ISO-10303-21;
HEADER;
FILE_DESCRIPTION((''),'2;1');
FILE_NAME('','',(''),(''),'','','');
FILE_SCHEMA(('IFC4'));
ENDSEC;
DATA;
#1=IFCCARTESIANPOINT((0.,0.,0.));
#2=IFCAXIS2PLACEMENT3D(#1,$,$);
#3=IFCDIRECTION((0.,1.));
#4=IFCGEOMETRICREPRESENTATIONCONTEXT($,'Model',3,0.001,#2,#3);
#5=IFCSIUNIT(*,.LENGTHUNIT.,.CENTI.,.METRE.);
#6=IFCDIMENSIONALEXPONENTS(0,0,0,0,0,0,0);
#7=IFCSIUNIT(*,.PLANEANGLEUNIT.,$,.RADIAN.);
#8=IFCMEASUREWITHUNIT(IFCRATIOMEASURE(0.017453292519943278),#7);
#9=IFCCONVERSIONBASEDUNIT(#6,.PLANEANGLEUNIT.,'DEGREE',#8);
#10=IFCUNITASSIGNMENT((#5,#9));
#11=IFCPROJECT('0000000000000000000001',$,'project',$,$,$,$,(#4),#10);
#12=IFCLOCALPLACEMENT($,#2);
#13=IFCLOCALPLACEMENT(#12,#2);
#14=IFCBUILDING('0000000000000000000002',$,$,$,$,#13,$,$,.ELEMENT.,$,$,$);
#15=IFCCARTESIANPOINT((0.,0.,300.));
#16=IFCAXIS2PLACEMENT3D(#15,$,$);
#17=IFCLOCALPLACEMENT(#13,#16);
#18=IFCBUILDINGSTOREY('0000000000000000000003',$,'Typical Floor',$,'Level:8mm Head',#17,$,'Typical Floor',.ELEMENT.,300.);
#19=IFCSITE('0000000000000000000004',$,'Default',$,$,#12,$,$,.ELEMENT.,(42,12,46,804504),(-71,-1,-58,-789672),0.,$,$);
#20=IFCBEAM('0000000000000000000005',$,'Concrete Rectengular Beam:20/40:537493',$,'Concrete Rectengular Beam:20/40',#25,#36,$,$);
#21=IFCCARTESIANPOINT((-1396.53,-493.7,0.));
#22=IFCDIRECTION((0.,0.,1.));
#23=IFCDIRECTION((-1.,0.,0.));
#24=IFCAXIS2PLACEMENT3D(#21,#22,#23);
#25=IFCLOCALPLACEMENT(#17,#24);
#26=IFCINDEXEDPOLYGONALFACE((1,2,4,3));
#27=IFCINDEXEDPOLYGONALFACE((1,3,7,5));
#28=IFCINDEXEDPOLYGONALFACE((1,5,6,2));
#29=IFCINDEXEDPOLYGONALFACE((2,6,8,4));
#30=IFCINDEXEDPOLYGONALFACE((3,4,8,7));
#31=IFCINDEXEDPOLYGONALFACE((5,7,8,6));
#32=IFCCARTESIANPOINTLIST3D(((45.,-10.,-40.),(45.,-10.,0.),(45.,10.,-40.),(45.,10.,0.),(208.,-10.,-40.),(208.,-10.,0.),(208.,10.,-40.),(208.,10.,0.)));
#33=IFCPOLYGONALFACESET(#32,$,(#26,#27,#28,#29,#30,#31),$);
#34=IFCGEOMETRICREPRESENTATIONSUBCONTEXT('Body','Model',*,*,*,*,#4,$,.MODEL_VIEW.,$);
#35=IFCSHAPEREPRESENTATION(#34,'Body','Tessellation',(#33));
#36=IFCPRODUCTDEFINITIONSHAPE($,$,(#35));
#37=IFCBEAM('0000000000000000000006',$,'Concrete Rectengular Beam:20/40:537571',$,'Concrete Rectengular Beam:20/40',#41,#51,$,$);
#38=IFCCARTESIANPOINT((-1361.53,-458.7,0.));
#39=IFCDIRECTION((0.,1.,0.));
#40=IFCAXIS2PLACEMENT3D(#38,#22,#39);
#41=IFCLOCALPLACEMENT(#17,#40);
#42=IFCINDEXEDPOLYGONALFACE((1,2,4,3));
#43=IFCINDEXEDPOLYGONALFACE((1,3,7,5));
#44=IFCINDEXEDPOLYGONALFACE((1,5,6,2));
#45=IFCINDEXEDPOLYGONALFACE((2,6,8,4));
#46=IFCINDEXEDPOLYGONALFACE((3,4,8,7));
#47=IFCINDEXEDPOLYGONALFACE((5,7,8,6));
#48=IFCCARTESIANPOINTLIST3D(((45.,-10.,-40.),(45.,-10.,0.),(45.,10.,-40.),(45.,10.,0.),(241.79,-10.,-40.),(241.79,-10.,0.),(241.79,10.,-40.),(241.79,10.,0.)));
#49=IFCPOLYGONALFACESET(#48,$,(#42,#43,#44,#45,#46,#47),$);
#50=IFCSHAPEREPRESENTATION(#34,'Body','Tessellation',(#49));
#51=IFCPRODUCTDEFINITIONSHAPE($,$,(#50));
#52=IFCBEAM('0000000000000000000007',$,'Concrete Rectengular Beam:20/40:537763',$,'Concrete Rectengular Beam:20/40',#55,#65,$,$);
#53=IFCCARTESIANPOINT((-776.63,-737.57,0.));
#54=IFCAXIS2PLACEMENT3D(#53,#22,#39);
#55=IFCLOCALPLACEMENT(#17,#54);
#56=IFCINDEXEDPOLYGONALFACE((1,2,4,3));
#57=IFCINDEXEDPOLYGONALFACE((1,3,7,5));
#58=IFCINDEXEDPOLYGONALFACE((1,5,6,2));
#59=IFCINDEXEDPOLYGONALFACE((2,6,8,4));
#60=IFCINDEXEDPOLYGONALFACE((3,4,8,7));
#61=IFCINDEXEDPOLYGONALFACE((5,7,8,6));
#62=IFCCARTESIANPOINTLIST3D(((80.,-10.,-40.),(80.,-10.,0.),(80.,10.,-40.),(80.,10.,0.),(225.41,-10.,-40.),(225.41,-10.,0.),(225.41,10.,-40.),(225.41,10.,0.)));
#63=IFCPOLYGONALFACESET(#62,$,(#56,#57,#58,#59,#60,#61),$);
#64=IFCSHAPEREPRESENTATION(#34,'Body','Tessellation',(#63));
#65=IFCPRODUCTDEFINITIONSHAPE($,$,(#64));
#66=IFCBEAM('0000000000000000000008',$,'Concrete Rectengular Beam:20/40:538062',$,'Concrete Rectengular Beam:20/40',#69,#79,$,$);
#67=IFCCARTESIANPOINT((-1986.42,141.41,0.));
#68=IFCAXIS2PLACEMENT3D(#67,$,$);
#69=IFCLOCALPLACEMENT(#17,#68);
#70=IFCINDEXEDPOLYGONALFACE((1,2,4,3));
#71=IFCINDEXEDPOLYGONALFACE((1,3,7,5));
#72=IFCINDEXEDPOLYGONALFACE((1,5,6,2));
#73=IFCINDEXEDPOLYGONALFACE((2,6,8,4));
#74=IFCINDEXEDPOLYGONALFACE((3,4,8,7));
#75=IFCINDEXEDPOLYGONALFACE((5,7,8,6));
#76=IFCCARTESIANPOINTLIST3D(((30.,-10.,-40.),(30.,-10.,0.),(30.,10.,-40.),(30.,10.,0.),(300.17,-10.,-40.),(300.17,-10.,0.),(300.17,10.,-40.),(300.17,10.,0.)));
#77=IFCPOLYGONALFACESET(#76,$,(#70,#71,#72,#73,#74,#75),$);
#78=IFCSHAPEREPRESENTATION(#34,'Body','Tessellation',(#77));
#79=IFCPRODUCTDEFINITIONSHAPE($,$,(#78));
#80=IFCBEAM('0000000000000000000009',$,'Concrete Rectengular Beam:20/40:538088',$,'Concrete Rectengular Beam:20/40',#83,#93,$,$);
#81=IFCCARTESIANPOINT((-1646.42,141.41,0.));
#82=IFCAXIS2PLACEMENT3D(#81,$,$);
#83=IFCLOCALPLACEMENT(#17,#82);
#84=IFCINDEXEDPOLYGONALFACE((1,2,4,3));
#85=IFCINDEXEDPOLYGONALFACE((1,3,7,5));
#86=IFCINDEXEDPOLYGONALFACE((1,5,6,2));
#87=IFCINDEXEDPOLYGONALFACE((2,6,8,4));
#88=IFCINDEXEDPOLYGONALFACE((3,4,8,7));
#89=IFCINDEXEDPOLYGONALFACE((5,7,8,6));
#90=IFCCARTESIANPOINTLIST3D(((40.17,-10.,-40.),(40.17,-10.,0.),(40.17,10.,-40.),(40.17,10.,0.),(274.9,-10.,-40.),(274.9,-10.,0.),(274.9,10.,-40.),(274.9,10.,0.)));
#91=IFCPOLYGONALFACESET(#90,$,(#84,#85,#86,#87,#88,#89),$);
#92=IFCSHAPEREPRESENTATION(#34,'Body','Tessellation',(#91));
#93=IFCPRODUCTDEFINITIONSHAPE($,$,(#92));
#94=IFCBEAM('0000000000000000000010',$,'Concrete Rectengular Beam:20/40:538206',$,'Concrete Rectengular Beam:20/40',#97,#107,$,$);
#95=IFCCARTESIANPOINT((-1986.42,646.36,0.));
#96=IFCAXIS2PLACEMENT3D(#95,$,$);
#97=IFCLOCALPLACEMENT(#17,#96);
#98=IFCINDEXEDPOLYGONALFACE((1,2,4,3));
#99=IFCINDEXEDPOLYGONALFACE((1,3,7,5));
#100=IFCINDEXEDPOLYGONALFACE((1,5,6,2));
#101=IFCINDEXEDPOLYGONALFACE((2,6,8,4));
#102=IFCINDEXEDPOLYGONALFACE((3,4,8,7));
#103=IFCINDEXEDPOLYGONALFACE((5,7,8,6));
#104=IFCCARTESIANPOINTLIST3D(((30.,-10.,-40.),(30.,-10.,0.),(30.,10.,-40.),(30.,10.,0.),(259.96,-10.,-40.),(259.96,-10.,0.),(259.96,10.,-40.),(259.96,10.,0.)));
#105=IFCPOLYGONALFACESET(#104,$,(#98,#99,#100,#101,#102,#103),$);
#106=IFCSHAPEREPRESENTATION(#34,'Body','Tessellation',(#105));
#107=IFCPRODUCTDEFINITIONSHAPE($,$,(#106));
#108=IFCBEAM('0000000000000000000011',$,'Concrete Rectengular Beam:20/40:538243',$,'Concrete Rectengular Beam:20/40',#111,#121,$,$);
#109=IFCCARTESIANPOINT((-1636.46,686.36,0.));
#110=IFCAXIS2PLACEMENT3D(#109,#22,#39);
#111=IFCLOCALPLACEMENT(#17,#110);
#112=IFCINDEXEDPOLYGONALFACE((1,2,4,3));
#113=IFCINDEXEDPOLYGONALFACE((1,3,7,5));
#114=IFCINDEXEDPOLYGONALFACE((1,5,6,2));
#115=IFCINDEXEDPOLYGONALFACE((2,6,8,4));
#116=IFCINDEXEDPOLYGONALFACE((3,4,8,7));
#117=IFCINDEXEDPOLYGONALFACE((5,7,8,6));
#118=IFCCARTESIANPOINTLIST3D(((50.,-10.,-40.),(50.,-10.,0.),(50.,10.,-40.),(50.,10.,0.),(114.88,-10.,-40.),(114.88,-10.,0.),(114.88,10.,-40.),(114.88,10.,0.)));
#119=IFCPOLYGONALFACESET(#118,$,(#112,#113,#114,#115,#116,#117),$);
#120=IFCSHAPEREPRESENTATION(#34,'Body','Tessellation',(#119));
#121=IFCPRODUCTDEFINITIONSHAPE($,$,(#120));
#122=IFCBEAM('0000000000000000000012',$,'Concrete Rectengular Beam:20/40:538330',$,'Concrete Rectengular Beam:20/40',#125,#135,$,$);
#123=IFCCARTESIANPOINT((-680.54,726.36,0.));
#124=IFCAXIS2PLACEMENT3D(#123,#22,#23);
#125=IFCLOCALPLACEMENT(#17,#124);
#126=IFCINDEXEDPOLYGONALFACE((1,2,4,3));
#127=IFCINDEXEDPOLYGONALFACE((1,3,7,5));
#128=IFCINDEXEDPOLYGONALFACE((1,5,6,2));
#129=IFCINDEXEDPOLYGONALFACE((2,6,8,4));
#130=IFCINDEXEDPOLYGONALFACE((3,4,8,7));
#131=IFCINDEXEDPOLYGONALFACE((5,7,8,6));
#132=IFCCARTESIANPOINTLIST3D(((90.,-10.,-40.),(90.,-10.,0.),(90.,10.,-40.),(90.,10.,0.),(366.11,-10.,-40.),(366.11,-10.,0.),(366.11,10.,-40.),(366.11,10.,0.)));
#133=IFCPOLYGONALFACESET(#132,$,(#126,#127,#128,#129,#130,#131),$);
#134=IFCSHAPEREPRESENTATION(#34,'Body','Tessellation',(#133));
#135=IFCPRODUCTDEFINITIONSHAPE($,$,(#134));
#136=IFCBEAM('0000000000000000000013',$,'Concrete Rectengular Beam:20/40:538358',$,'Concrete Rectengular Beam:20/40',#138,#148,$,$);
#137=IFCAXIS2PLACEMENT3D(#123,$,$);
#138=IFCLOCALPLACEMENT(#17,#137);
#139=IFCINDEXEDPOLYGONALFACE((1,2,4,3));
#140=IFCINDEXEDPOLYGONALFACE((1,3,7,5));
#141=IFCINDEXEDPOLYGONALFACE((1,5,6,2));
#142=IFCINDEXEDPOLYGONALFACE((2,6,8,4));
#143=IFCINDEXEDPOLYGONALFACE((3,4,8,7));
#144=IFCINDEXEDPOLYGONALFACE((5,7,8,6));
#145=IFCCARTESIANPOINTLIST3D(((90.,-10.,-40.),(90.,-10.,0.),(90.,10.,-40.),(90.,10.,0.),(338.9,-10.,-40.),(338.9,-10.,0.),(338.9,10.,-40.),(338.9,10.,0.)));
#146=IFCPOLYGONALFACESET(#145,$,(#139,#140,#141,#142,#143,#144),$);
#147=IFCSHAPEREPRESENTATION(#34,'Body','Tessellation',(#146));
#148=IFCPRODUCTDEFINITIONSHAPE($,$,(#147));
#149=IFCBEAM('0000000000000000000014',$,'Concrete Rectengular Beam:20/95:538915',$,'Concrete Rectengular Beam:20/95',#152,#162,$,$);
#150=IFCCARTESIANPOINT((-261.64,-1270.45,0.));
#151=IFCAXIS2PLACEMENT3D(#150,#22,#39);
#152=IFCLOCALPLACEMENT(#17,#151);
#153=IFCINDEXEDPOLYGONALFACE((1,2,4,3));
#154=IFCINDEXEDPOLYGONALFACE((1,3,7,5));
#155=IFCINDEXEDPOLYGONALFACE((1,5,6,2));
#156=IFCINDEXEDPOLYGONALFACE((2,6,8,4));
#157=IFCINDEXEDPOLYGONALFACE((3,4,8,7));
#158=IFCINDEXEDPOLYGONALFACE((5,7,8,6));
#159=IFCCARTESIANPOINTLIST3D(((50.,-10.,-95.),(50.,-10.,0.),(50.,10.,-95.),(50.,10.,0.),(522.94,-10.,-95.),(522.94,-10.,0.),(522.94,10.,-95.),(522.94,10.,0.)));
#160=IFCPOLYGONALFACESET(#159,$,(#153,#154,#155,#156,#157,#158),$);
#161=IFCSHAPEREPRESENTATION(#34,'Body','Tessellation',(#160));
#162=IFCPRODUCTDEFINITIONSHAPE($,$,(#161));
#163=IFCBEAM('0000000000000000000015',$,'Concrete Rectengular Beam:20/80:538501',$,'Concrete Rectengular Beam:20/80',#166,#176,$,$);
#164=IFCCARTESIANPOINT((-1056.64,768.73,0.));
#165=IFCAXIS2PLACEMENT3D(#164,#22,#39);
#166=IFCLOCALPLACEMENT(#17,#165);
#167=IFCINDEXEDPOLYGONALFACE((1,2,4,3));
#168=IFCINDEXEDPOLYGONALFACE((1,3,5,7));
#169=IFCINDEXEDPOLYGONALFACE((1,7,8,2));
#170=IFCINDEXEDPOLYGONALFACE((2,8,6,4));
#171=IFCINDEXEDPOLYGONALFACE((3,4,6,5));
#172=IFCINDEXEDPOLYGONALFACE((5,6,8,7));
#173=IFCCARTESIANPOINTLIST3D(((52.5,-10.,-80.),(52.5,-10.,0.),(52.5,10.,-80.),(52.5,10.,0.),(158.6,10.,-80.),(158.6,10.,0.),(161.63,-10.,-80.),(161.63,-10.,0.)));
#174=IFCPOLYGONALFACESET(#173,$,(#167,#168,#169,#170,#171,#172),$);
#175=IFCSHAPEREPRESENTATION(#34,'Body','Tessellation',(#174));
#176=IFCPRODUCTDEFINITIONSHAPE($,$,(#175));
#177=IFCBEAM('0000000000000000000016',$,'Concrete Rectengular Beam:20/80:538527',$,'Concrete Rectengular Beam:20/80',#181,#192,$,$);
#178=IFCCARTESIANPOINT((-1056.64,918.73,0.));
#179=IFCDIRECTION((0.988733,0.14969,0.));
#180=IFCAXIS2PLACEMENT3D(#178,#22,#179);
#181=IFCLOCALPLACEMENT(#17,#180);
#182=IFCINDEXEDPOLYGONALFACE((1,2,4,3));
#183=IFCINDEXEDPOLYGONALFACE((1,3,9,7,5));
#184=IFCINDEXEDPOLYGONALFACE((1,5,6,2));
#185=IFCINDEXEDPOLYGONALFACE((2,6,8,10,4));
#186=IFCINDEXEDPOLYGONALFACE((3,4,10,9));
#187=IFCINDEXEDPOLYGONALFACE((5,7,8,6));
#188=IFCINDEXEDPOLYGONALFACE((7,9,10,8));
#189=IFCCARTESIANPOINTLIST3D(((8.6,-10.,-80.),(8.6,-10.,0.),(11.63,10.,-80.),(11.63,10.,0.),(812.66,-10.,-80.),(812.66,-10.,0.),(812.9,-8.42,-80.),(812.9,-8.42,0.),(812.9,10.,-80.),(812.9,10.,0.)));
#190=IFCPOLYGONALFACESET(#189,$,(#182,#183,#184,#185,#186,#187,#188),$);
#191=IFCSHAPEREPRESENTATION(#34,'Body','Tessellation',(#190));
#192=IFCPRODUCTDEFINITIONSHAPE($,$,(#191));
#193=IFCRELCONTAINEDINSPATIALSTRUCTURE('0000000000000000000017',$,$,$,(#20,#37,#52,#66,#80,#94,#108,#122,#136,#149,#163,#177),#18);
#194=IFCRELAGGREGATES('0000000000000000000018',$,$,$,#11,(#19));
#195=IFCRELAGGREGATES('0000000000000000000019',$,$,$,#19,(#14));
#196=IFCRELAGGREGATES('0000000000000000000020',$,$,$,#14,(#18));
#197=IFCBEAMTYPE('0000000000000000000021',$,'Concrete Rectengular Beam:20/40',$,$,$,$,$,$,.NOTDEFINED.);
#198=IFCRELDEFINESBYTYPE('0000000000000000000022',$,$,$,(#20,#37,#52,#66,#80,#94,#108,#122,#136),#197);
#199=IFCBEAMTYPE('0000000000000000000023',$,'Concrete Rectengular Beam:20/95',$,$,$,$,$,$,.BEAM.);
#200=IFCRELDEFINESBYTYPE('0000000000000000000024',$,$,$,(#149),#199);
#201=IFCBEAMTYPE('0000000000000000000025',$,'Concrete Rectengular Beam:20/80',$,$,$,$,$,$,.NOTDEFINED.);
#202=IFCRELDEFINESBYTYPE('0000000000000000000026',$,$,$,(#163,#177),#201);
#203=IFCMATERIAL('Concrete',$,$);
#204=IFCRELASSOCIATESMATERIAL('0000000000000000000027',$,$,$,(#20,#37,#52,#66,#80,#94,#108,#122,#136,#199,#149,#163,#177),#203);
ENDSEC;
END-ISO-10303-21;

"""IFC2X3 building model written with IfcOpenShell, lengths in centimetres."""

from ifc_helpers import new_model, entity, si_unit, converted_unit, direction, frame, frame_2d, origin, origin_2d_with_axis, place, context, subcontext, project, spatial, rectangle, extrude, clip, halfspace, material, type_object, element, save


model = new_model("IFC2X3")

# Units and contexts
model_context = context("Model", 3, precision=0.001, world=origin(), true_north=direction((0.0, 1.0)))
body_context = subcontext(model_context, "Body", "Model", "MODEL_VIEW")
ifc_project = project(units=[si_unit("LENGTHUNIT", "METRE", prefix="CENTI"), converted_unit("PLANEANGLEUNIT", "DEGREE", entity("IfcRatioMeasure", 0.017453292519943278), si_unit("PLANEANGLEUNIT", "RADIAN"), dimensions=[0, 0, 0, 0, 0, 0, 0])], contexts=[model_context])

# Site, building, storey
site_placement = place(None, origin())
site = spatial("IfcSite", under=ifc_project, at=site_placement, Name="Default", CompositionType="ELEMENT", RefLatitude=(42, 12, 46, 804504), RefLongitude=(-71, -1, -58, -789672), RefElevation=0.0)
building_placement = place(site_placement, origin())
building = spatial("IfcBuilding", under=site, at=building_placement, CompositionType="ELEMENT")
storey_placement = place(building_placement, frame((0.0, 0.0, 300.0)))
storey = spatial("IfcBuildingStorey", under=building, at=storey_placement, Name="Typical Floor", ObjectType="Level:8mm Head", LongName="Typical Floor", CompositionType="ELEMENT", Elevation=300.0)

# Beams
ifc_material = material(Name="Concrete")
beam_type_1 = type_object("IfcBeamType", Name="Concrete Rectengular Beam:20/40", PredefinedType="NOTDEFINED")
beam_1_placement = place(storey_placement, frame((-1396.53, -493.7, 0.0), z_axis=(0.0, 0.0, 1.0), x_axis=(-1.0, 0.0, 0.0)))
element("IfcBeam", 1, at=beam_1_placement, inside=storey, type_object=beam_type_1, material=ifc_material, Name="Concrete Rectengular Beam:20/40:537493", ObjectType="Concrete Rectengular Beam:20/40", context=body_context, shape_type="SweptSolid", body=[
    extrude(rectangle(XDim=40.0, YDim=20.0, at=frame_2d((0.0, 0.0), x_axis=(1.0, 0.0))), frame((45.0, 0.0, -20.0), z_axis=(1.0, 0.0, 0.0), x_axis=(0.0, 0.0, -1.0)), (0.0, 0.0, 1.0), 163.0),
])
beam_2_placement = place(storey_placement, frame((-1361.53, -458.7, 0.0), z_axis=(0.0, 0.0, 1.0), x_axis=(0.0, 1.0, 0.0)))
element("IfcBeam", 2, at=beam_2_placement, inside=storey, type_object=beam_type_1, material=ifc_material, Name="Concrete Rectengular Beam:20/40:537571", ObjectType="Concrete Rectengular Beam:20/40", context=body_context, shape_type="SweptSolid", body=[
    extrude(rectangle(XDim=40.0, YDim=20.0, at=frame_2d((0.0, 0.0), x_axis=(1.0, 0.0))), frame((45.0, 0.0, -20.0), z_axis=(1.0, 0.0, 0.0), x_axis=(0.0, 0.0, -1.0)), (0.0, 0.0, 1.0), 196.79),
])
beam_3_placement = place(storey_placement, frame((-776.63, -737.57, 0.0), z_axis=(0.0, 0.0, 1.0), x_axis=(0.0, 1.0, 0.0)))
element("IfcBeam", 3, at=beam_3_placement, inside=storey, type_object=beam_type_1, material=ifc_material, Name="Concrete Rectengular Beam:20/40:537763", ObjectType="Concrete Rectengular Beam:20/40", context=body_context, shape_type="SweptSolid", body=[
    extrude(rectangle(XDim=40.0, YDim=20.0, at=frame_2d((0.0, 0.0), x_axis=(1.0, 0.0))), frame((80.0, 0.0, -20.0), z_axis=(1.0, 0.0, 0.0), x_axis=(0.0, 0.0, -1.0)), (0.0, 0.0, 1.0), 145.41),
])
beam_4_placement = place(storey_placement, frame((-1986.42, 141.41, 0.0)))
element("IfcBeam", 4, at=beam_4_placement, inside=storey, type_object=beam_type_1, material=ifc_material, Name="Concrete Rectengular Beam:20/40:538062", ObjectType="Concrete Rectengular Beam:20/40", context=body_context, shape_type="SweptSolid", body=[
    extrude(rectangle(XDim=40.0, YDim=20.0, at=frame_2d((0.0, 0.0), x_axis=(1.0, 0.0))), frame((30.0, 0.0, -20.0), z_axis=(1.0, 0.0, 0.0), x_axis=(0.0, 0.0, -1.0)), (0.0, 0.0, 1.0), 270.17),
])
beam_5_placement = place(storey_placement, frame((-1646.42, 141.41, 0.0)))
element("IfcBeam", 5, at=beam_5_placement, inside=storey, type_object=beam_type_1, material=ifc_material, Name="Concrete Rectengular Beam:20/40:538088", ObjectType="Concrete Rectengular Beam:20/40", context=body_context, shape_type="SweptSolid", body=[
    extrude(rectangle(XDim=40.0, YDim=20.0, at=frame_2d((0.0, 0.0), x_axis=(1.0, 0.0))), frame((40.17, 0.0, -20.0), z_axis=(1.0, 0.0, 0.0), x_axis=(0.0, 0.0, -1.0)), (0.0, 0.0, 1.0), 234.72),
])
beam_6_placement = place(storey_placement, frame((-1986.42, 646.36, 0.0)))
element("IfcBeam", 6, at=beam_6_placement, inside=storey, type_object=beam_type_1, material=ifc_material, Name="Concrete Rectengular Beam:20/40:538206", ObjectType="Concrete Rectengular Beam:20/40", context=body_context, shape_type="SweptSolid", body=[
    extrude(rectangle(XDim=40.0, YDim=20.0, at=frame_2d((0.0, 0.0), x_axis=(1.0, 0.0))), frame((30.0, 0.0, -20.0), z_axis=(1.0, 0.0, 0.0), x_axis=(0.0, 0.0, -1.0)), (0.0, 0.0, 1.0), 229.96),
])
beam_7_placement = place(storey_placement, frame((-1636.46, 686.36, 0.0), z_axis=(0.0, 0.0, 1.0), x_axis=(0.0, 1.0, 0.0)))
element("IfcBeam", 7, at=beam_7_placement, inside=storey, type_object=beam_type_1, material=ifc_material, Name="Concrete Rectengular Beam:20/40:538243", ObjectType="Concrete Rectengular Beam:20/40", context=body_context, shape_type="SweptSolid", body=[
    extrude(rectangle(XDim=40.0, YDim=20.0, at=origin_2d_with_axis()), frame((50.0, 0.0, -20.0), z_axis=(1.0, 0.0, 0.0), x_axis=(0.0, 0.0, -1.0)), (0.0, 0.0, 1.0), 64.88),
])
beam_8_placement = place(storey_placement, frame((-680.54, 726.36, 0.0), z_axis=(0.0, 0.0, 1.0), x_axis=(-1.0, 0.0, 0.0)))
element("IfcBeam", 8, at=beam_8_placement, inside=storey, type_object=beam_type_1, material=ifc_material, Name="Concrete Rectengular Beam:20/40:538330", ObjectType="Concrete Rectengular Beam:20/40", context=body_context, shape_type="SweptSolid", body=[
    extrude(rectangle(XDim=40.0, YDim=20.0, at=frame_2d((0.0, 0.0), x_axis=(1.0, 0.0))), frame((90.0, 0.0, -20.0), z_axis=(1.0, 0.0, 0.0), x_axis=(0.0, 0.0, -1.0)), (0.0, 0.0, 1.0), 276.11),
])
beam_9_placement = place(storey_placement, frame((-680.54, 726.36, 0.0)))
element("IfcBeam", 9, at=beam_9_placement, inside=storey, type_object=beam_type_1, material=ifc_material, Name="Concrete Rectengular Beam:20/40:538358", ObjectType="Concrete Rectengular Beam:20/40", context=body_context, shape_type="SweptSolid", body=[
    extrude(rectangle(XDim=40.0, YDim=20.0, at=frame_2d((0.0, 0.0), x_axis=(1.0, 0.0))), frame((90.0, 0.0, -20.0), z_axis=(1.0, 0.0, 0.0), x_axis=(0.0, 0.0, -1.0)), (0.0, 0.0, 1.0), 248.9),
])
beam_type_2 = type_object("IfcBeamType", Name="Concrete Rectengular Beam:20/95", PredefinedType="BEAM", material=ifc_material)
beam_10_placement = place(storey_placement, frame((-261.64, -1270.45, 0.0), z_axis=(0.0, 0.0, 1.0), x_axis=(0.0, 1.0, 0.0)))
element("IfcBeam", 10, at=beam_10_placement, inside=storey, type_object=beam_type_2, material=ifc_material, Name="Concrete Rectengular Beam:20/95:538915", ObjectType="Concrete Rectengular Beam:20/95", context=body_context, shape_type="SweptSolid", body=[
    extrude(rectangle(XDim=95.0, YDim=20.0, at=frame_2d((0.0, 0.0), x_axis=(1.0, 0.0))), frame((50.0, 0.0, -47.5), z_axis=(1.0, 0.0, 0.0), x_axis=(0.0, 0.0, -1.0)), (0.0, 0.0, 1.0), 472.94),
])
beam_type_3 = type_object("IfcBeamType", Name="Concrete Rectengular Beam:20/80", PredefinedType="NOTDEFINED")
beam_11_placement = place(storey_placement, frame((-1056.64, 768.73, 0.0), z_axis=(0.0, 0.0, 1.0), x_axis=(0.0, 1.0, 0.0)))
element("IfcBeam", 11, at=beam_11_placement, inside=storey, type_object=beam_type_3, material=ifc_material, Name="Concrete Rectengular Beam:20/80:538501", ObjectType="Concrete Rectengular Beam:20/80", context=body_context, shape_type="SweptSolid", body=[
    clip(extrude(rectangle(XDim=80.0, YDim=20.0, at=frame_2d((0.0, 0.0), x_axis=(1.0, 0.0))), frame((52.5, 0.0, -40.0), z_axis=(1.0, 0.0, 0.0), x_axis=(0.0, 0.0, -1.0)), (0.0, 0.0, 1.0), 109.13), halfspace(frame((157.97, 14.17, 0.0), z_axis=(0.988733, 0.14969, 0.0), x_axis=(0.14969, -0.988733, 0.0)), False)),
])
beam_12_placement = place(storey_placement, frame((-1056.64, 918.73, 0.0), z_axis=(0.0, 0.0, 1.0), x_axis=(0.988733, 0.14969, 0.0)))
element("IfcBeam", 12, at=beam_12_placement, inside=storey, type_object=beam_type_3, material=ifc_material, Name="Concrete Rectengular Beam:20/80:538527", ObjectType="Concrete Rectengular Beam:20/80", context=body_context, shape_type="SweptSolid", body=[
    clip(clip(extrude(rectangle(XDim=80.0, YDim=20.0, at=origin_2d_with_axis()), frame((8.6, 0.0, -40.0), z_axis=(1.0, 0.0, 0.0), x_axis=(0.0, 0.0, -1.0)), (0.0, 0.0, 1.0), 804.3), halfspace(frame((8.21, -12.54, 0.0), z_axis=(-0.988733, 0.14969, 0.0), x_axis=(-0.14969, -0.988733, 0.0)), False)), halfspace(frame((815.98, 11.93, 0.0), z_axis=(0.988733, -0.14969, 0.0), x_axis=(-0.14969, -0.988733, 0.0)), False)),
])

save(model, "model.ifc")
